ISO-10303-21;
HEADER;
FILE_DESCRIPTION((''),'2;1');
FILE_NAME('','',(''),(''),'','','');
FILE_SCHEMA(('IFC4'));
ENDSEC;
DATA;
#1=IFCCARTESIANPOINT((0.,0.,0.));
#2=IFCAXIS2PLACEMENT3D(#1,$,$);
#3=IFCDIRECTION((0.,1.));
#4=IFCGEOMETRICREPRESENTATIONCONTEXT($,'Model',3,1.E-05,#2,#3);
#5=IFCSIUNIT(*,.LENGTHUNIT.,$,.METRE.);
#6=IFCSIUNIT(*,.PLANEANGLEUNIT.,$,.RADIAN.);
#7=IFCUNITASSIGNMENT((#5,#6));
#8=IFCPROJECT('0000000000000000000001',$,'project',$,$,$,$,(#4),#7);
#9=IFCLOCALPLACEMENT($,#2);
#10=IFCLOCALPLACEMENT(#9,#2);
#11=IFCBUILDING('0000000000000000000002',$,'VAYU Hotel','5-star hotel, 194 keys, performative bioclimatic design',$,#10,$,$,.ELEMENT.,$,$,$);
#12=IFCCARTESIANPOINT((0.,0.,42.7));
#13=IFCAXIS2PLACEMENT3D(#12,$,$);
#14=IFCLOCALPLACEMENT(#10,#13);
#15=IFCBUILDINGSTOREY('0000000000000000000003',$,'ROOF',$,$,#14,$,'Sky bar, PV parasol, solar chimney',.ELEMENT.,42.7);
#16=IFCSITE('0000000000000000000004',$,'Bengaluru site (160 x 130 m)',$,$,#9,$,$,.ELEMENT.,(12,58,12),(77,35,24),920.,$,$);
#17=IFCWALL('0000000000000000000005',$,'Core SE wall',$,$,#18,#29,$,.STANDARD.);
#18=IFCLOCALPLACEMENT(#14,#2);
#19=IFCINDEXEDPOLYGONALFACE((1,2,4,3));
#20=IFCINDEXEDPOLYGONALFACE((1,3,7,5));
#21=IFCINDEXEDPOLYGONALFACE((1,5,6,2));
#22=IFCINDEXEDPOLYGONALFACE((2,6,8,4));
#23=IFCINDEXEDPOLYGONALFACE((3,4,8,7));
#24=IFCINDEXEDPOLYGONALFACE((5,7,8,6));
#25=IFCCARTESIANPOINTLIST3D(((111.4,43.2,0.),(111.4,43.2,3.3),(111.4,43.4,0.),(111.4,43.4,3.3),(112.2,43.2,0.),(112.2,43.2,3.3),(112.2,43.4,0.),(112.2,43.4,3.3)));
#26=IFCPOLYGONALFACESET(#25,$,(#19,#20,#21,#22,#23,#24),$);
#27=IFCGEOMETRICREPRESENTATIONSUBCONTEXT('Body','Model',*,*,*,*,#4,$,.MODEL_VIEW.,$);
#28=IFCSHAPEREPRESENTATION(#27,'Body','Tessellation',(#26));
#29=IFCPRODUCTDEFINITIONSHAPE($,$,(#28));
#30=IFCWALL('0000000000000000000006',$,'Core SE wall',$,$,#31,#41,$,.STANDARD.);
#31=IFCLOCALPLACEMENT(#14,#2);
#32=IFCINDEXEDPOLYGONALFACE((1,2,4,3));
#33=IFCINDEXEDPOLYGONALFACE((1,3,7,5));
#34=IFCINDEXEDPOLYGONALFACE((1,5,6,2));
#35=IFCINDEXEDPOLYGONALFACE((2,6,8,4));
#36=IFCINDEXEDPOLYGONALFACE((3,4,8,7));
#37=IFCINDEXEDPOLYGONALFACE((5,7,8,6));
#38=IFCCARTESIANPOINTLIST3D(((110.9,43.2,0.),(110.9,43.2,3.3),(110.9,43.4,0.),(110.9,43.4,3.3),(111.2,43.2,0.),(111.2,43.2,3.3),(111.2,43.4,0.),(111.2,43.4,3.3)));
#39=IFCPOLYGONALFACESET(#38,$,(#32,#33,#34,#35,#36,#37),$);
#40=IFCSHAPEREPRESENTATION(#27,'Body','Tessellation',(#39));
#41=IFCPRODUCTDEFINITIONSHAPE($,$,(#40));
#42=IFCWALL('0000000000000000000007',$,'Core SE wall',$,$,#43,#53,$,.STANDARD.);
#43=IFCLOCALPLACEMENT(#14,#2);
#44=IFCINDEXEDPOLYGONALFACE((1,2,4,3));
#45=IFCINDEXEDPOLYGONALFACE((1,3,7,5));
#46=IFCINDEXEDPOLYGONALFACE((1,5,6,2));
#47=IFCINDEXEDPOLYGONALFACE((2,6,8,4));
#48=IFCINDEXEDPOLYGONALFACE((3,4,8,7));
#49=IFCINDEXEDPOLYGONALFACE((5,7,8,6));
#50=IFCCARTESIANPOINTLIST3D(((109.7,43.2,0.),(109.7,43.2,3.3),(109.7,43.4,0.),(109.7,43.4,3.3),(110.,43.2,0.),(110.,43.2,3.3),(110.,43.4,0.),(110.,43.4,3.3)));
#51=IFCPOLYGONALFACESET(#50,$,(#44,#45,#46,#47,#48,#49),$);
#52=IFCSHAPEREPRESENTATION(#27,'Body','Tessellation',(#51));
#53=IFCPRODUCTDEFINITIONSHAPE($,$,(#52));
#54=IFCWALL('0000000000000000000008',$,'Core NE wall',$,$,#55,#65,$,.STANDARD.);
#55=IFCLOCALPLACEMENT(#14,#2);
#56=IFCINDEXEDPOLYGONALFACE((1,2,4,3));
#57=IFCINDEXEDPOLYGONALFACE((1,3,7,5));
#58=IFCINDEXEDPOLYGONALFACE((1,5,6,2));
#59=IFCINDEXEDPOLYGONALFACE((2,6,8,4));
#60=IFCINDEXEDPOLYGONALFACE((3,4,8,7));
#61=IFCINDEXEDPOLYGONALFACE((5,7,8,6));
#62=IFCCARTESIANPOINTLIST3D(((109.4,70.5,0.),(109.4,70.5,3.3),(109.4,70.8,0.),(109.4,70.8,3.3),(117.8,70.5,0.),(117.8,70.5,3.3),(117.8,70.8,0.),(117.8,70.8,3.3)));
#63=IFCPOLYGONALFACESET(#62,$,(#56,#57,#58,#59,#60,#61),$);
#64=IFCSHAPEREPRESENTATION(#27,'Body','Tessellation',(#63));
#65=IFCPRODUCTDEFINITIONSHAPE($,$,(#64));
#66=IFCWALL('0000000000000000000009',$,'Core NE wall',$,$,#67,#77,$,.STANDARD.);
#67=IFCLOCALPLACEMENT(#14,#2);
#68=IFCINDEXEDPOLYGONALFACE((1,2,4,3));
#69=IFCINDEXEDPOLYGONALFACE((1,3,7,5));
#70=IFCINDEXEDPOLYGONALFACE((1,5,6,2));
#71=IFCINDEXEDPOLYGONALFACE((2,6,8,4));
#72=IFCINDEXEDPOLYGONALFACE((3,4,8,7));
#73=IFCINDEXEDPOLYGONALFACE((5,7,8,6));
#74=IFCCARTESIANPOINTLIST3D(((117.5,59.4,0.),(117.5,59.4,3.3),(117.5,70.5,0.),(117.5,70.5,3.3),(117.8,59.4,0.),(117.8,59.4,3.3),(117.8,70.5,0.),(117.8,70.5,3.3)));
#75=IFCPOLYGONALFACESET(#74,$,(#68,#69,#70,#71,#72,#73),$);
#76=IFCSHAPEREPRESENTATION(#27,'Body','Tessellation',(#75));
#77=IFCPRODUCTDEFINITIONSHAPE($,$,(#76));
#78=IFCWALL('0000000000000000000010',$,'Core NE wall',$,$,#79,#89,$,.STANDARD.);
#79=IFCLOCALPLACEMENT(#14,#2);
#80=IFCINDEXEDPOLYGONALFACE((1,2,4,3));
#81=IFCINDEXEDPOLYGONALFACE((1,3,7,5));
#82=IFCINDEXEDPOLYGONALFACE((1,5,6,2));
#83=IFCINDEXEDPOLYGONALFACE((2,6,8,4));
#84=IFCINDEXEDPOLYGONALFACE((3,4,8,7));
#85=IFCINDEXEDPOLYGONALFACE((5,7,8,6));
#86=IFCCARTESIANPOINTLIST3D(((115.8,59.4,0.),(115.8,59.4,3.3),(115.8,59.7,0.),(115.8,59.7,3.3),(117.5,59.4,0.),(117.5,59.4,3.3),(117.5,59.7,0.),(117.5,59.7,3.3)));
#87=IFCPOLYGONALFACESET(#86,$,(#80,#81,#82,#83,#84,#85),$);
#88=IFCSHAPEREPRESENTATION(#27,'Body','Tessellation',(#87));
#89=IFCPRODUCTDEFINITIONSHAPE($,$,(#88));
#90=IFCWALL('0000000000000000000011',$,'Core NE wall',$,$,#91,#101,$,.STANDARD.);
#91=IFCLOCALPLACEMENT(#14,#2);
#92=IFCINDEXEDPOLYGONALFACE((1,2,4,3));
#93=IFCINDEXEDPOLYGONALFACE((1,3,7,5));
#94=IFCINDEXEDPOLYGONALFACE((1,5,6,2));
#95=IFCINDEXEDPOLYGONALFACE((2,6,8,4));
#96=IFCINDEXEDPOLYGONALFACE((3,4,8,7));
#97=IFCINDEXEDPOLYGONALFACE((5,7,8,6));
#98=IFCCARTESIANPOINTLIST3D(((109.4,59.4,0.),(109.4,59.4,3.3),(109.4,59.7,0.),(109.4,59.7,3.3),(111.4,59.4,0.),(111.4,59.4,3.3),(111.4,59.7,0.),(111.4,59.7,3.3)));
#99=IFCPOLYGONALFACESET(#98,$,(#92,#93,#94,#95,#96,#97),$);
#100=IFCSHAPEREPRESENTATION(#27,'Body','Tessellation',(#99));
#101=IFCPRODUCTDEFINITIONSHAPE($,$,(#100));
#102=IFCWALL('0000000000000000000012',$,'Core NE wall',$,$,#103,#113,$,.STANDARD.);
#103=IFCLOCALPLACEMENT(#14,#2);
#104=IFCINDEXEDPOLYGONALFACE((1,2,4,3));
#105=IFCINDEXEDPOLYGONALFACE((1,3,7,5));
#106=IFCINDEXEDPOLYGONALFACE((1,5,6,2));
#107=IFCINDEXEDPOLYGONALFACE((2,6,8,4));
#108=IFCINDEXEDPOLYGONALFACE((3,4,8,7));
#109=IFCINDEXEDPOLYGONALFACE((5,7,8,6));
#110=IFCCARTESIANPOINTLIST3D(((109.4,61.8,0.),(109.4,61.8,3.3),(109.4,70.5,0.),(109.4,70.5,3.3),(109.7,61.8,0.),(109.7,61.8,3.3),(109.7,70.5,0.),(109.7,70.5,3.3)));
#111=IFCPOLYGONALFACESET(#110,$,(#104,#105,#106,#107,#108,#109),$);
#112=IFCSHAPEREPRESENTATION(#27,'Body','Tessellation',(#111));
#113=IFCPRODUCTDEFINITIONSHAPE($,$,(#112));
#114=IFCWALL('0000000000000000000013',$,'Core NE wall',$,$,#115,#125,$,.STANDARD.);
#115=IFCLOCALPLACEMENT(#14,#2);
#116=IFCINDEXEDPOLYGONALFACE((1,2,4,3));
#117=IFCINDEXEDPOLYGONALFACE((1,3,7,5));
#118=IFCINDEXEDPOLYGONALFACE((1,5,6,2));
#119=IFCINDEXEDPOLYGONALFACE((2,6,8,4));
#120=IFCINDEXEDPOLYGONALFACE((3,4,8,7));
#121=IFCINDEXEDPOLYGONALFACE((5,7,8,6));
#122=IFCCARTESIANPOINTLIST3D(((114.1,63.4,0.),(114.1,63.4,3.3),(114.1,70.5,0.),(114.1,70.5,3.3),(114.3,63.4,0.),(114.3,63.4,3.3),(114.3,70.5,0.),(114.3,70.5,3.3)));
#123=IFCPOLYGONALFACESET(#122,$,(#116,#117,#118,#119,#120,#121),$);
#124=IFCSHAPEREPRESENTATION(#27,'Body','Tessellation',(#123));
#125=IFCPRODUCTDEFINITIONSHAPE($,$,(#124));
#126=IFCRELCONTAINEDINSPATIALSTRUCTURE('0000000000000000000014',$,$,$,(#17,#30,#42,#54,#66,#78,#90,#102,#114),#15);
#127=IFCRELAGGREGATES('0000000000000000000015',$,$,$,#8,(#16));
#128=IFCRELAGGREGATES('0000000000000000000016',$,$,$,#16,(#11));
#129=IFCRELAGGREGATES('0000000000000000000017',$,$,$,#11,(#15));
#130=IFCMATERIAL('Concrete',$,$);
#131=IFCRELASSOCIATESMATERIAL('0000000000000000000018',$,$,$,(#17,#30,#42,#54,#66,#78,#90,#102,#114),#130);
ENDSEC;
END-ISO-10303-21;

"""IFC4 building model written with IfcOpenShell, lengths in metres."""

from ifc_helpers import new_model, si_unit, direction, frame, origin, place, context, subcontext, project, spatial, polyline, outline, extrude, material, element, save


model = new_model("IFC4")

# Units and contexts
model_context = context("Model", 3, precision=1e-05, world=origin(), true_north=direction((0.0, 1.0)))
body_context = subcontext(model_context, "Body", "Model", "MODEL_VIEW")
ifc_project = project(units=[si_unit("LENGTHUNIT", "METRE"), si_unit("PLANEANGLEUNIT", "RADIAN")], contexts=[model_context])

# Site, building, storey
site_placement = place(None, origin())
site = spatial("IfcSite", under=ifc_project, at=site_placement, Name="Bengaluru site (160 x 130 m)", CompositionType="ELEMENT", RefLatitude=(12, 58, 12), RefLongitude=(77, 35, 24), RefElevation=920.0)
building_placement = place(site_placement, origin())
building = spatial("IfcBuilding", under=site, at=building_placement, Name="VAYU Hotel", Description="5-star hotel, 194 keys, performative bioclimatic design", CompositionType="ELEMENT")
storey_placement = place(building_placement, frame((0.0, 0.0, 42.7)))
storey = spatial("IfcBuildingStorey", under=building, at=storey_placement, Name="ROOF", LongName="Sky bar, PV parasol, solar chimney", CompositionType="ELEMENT", Elevation=42.7)

# Walls
ifc_material = material(Name="Concrete")
wall_1_placement = place(storey_placement, origin())
element("IfcWall", 1, at=wall_1_placement, inside=storey, material=ifc_material, Name="Core SE wall", PredefinedType="STANDARD", context=body_context, shape_type="SweptSolid", body=[
    extrude(outline(polyline([(111.4, 43.4), (112.2, 43.4), (112.2, 43.2), (111.4, 43.2), (111.4, 43.4)])), origin(), (0.0, 0.0, 1.0), 3.3),
])
wall_2_placement = place(storey_placement, origin())
element("IfcWall", 2, at=wall_2_placement, inside=storey, material=ifc_material, Name="Core SE wall", PredefinedType="STANDARD", context=body_context, shape_type="SweptSolid", body=[
    extrude(outline(polyline([(110.9, 43.4), (111.2, 43.4), (111.2, 43.2), (110.9, 43.2), (110.9, 43.4)])), origin(), (0.0, 0.0, 1.0), 3.3),
])
wall_3_placement = place(storey_placement, origin())
element("IfcWall", 3, at=wall_3_placement, inside=storey, material=ifc_material, Name="Core SE wall", PredefinedType="STANDARD", context=body_context, shape_type="SweptSolid", body=[
    extrude(outline(polyline([(109.7, 43.4), (110.0, 43.4), (110.0, 43.2), (109.7, 43.2), (109.7, 43.4)])), origin(), (0.0, 0.0, 1.0), 3.3),
])
wall_4_placement = place(storey_placement, origin())
element("IfcWall", 4, at=wall_4_placement, inside=storey, material=ifc_material, Name="Core NE wall", PredefinedType="STANDARD", context=body_context, shape_type="SweptSolid", body=[
    extrude(outline(polyline([(109.4, 70.8), (117.8, 70.8), (117.8, 70.5), (109.4, 70.5), (109.4, 70.8)])), origin(), (0.0, 0.0, 1.0), 3.3),
])
wall_5_placement = place(storey_placement, origin())
element("IfcWall", 5, at=wall_5_placement, inside=storey, material=ifc_material, Name="Core NE wall", PredefinedType="STANDARD", context=body_context, shape_type="SweptSolid", body=[
    extrude(outline(polyline([(117.5, 59.4), (117.5, 70.5), (117.8, 70.5), (117.8, 59.4), (117.5, 59.4)])), origin(), (0.0, 0.0, 1.0), 3.3),
])
wall_6_placement = place(storey_placement, origin())
element("IfcWall", 6, at=wall_6_placement, inside=storey, material=ifc_material, Name="Core NE wall", PredefinedType="STANDARD", context=body_context, shape_type="SweptSolid", body=[
    extrude(outline(polyline([(115.8, 59.7), (117.5, 59.7), (117.5, 59.4), (115.8, 59.4), (115.8, 59.7)])), origin(), (0.0, 0.0, 1.0), 3.3),
])
wall_7_placement = place(storey_placement, origin())
element("IfcWall", 7, at=wall_7_placement, inside=storey, material=ifc_material, Name="Core NE wall", PredefinedType="STANDARD", context=body_context, shape_type="SweptSolid", body=[
    extrude(outline(polyline([(109.4, 59.7), (111.4, 59.7), (111.4, 59.4), (109.4, 59.4), (109.4, 59.7)])), origin(), (0.0, 0.0, 1.0), 3.3),
])
wall_8_placement = place(storey_placement, origin())
element("IfcWall", 8, at=wall_8_placement, inside=storey, material=ifc_material, Name="Core NE wall", PredefinedType="STANDARD", context=body_context, shape_type="SweptSolid", body=[
    extrude(outline(polyline([(109.4, 61.8), (109.4, 70.5), (109.7, 70.5), (109.7, 61.8), (109.4, 61.8)])), origin(), (0.0, 0.0, 1.0), 3.3),
])
wall_9_placement = place(storey_placement, origin())
element("IfcWall", 9, at=wall_9_placement, inside=storey, material=ifc_material, Name="Core NE wall", PredefinedType="STANDARD", context=body_context, shape_type="SweptSolid", body=[
    extrude(outline(polyline([(114.1, 63.4), (114.1, 70.5), (114.3, 70.5), (114.3, 63.4), (114.1, 63.4)])), origin(), (0.0, 0.0, 1.0), 3.3),
])

save(model, "model.ifc")
